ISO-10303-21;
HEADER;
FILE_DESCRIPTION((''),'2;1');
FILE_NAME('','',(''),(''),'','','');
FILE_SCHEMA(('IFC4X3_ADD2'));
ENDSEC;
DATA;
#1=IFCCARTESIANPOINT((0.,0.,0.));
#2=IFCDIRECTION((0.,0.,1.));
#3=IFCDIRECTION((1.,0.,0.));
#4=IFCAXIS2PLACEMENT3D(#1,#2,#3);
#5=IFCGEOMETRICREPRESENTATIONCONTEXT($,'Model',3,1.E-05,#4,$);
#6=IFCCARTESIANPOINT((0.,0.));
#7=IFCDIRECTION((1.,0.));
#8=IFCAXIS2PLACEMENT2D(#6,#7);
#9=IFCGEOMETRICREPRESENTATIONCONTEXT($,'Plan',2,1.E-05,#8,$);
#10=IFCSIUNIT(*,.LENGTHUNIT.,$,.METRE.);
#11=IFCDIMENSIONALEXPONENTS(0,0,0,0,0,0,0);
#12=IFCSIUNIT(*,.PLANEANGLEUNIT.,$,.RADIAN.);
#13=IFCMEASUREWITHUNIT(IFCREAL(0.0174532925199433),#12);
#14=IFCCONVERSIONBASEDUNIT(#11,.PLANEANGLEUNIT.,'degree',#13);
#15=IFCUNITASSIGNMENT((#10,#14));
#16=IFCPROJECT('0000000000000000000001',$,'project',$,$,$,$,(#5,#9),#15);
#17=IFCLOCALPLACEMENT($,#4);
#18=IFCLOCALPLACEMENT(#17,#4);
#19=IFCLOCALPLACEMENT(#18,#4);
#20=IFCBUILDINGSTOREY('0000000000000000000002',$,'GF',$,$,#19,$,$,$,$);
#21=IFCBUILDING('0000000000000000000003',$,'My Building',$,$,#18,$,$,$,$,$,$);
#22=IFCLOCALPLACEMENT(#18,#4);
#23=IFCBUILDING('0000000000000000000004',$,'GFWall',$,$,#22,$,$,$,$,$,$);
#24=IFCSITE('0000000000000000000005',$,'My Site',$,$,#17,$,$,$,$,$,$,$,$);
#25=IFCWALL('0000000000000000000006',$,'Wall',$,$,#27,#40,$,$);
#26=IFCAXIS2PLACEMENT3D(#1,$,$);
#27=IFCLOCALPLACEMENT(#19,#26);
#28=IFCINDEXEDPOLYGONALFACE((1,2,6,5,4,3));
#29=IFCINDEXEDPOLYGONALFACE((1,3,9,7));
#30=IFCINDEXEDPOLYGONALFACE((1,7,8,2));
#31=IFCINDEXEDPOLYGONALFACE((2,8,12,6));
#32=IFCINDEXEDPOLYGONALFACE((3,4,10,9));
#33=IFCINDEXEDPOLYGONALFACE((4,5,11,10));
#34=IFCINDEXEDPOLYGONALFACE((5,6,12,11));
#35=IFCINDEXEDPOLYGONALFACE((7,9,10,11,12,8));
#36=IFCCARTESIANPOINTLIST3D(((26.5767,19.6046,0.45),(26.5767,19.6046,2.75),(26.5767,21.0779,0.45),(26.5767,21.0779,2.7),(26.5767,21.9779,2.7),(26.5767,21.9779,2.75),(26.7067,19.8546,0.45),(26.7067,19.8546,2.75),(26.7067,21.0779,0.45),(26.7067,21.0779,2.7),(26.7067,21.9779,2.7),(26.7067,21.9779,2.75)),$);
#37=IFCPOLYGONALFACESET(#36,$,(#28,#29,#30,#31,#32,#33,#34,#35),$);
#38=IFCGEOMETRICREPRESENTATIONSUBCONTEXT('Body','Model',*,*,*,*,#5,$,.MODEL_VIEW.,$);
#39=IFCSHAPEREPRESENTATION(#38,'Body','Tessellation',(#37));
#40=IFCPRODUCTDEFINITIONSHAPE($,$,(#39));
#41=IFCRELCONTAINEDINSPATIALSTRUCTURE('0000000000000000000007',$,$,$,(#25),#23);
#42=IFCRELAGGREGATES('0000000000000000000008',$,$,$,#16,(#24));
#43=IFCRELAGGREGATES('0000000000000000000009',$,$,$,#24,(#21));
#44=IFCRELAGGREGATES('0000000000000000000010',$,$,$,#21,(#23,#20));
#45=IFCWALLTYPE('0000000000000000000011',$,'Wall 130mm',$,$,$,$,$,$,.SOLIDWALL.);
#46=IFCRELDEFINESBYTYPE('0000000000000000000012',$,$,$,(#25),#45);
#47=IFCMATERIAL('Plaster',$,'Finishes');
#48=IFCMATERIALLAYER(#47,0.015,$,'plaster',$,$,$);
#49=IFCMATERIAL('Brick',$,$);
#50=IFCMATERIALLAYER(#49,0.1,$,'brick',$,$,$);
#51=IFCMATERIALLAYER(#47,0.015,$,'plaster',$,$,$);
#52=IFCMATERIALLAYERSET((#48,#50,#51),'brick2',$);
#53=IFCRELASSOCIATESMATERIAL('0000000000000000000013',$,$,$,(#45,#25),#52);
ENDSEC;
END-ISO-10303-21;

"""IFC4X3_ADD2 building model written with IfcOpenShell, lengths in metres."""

from ifc_helpers import new_model, entity, si_unit, converted_unit, frame, origin_with_axes, origin_2d_with_axis, place, context, subcontext, project, spatial, line, indexed_curve, outline, extrude, source, transform, mapped, material, layer, layer_set, layer_usage, type_object, element, save


model = new_model("IFC4X3_ADD2")

# Units and contexts
model_context = context("Model", 3, precision=1e-05, world=origin_with_axes())
plan_context = context("Plan", 2, precision=1e-05, world=origin_2d_with_axis())
body_context_1 = subcontext(model_context, "Body", "Model", "MODEL_VIEW")
ifc_project = project(units=[si_unit("LENGTHUNIT", "METRE"), converted_unit("PLANEANGLEUNIT", "degree", entity("IfcReal", 0.0174532925199433), si_unit("PLANEANGLEUNIT", "RADIAN"), dimensions=[0, 0, 0, 0, 0, 0, 0])], contexts=[model_context, plan_context])

# Site, buildings
site_placement = place(None, origin_with_axes())
site = spatial("IfcSite", under=ifc_project, at=site_placement, Name="My Site")
building_1_placement = place(site_placement, origin_with_axes())
building_1 = spatial("IfcBuilding", under=site, at=building_1_placement, Name="My Building")
building_2_placement = place(building_1_placement, origin_with_axes())
building_2 = spatial("IfcBuilding", under=building_1, at=building_2_placement, Name="GFWall")

# Wall, opening
ifc_material_1 = material(Name="Plaster", Category="Finishes")
ifc_layer_1 = layer(ifc_material_1, 0.015, Name="plaster")
ifc_material_2 = material(Name="Brick")
ifc_layer_2 = layer(ifc_material_2, 0.1, Name="brick")
ifc_layer_3 = layer(ifc_material_1, 0.015, Name="plaster")
ifc_layer_set_1 = layer_set([ifc_layer_1, ifc_layer_2, ifc_layer_3], Name="brick2")
wall_type_1 = type_object("IfcWallType", Name="Wall 130mm", PredefinedType="SOLIDWALL", material=ifc_layer_set_1)
shared_shape_1 = source(origin_with_axes(), body_context_1, "Body", "SweptSolid", [
    extrude(outline(indexed_curve([(0.0, 2.25), (0.9, 2.25), (0.9, 0.0), (0.0, 0.0), (0.0, 2.25)])), frame((0.0, -0.6, 0.0), z_axis=(0.0, -1.0, 0.0), x_axis=(1.0, 0.0, 0.0)), (0.0, 0.0, -1.0), 1.2),
])
ifc_layer_usage_1 = layer_usage(ifc_layer_set_1, "AXIS2", "POSITIVE", 0.0)
wall_1_placement = place(building_2_placement, frame((26.7067, 19.6046, 0.45), z_axis=(0.0, 0.0, 1.0), x_axis=(0.0, 1.0, 0.0)))
wall_1 = element("IfcWall", 1, at=wall_1_placement, inside=building_2, type_object=wall_type_1, material=ifc_layer_usage_1, Name="Wall", context=body_context_1, shape_type="SweptSolid", body=[
    extrude(outline(indexed_curve([(0.25, 0.0), (0.0, 0.13), (2.3733, 0.13), (2.3733, 0.0)], segments=[line(1, 2, 3, 4, 1)])), origin_with_axes(), (0.0, 0.0, 1.0), 2.3),
])
opening_1_placement = place(wall_1_placement, frame((2.3733, 0.071, 0.0), z_axis=(0.0, 0.0, 1.0), x_axis=(-1.0, 0.0, 0.0)))
element("IfcOpeningElement", 2, at=opening_1_placement, cuts=wall_1, PredefinedType="OPENING", context=body_context_1, shape_type="MappedRepresentation", body=[
    mapped(shared_shape_1, transform((0.0, 0.0, 0.0), x_axis=(1.0, 0.0, 0.0), y_axis=(0.0, 1.0, 0.0), z_axis=(0.0, 0.0, 1.0), scale=1.0)),
])

# Shared definitions
storey_placement = place(building_1_placement, origin_with_axes())
storey = spatial("IfcBuildingStorey", under=building_1, at=storey_placement, Name="GF")

save(model, "model.ifc")
